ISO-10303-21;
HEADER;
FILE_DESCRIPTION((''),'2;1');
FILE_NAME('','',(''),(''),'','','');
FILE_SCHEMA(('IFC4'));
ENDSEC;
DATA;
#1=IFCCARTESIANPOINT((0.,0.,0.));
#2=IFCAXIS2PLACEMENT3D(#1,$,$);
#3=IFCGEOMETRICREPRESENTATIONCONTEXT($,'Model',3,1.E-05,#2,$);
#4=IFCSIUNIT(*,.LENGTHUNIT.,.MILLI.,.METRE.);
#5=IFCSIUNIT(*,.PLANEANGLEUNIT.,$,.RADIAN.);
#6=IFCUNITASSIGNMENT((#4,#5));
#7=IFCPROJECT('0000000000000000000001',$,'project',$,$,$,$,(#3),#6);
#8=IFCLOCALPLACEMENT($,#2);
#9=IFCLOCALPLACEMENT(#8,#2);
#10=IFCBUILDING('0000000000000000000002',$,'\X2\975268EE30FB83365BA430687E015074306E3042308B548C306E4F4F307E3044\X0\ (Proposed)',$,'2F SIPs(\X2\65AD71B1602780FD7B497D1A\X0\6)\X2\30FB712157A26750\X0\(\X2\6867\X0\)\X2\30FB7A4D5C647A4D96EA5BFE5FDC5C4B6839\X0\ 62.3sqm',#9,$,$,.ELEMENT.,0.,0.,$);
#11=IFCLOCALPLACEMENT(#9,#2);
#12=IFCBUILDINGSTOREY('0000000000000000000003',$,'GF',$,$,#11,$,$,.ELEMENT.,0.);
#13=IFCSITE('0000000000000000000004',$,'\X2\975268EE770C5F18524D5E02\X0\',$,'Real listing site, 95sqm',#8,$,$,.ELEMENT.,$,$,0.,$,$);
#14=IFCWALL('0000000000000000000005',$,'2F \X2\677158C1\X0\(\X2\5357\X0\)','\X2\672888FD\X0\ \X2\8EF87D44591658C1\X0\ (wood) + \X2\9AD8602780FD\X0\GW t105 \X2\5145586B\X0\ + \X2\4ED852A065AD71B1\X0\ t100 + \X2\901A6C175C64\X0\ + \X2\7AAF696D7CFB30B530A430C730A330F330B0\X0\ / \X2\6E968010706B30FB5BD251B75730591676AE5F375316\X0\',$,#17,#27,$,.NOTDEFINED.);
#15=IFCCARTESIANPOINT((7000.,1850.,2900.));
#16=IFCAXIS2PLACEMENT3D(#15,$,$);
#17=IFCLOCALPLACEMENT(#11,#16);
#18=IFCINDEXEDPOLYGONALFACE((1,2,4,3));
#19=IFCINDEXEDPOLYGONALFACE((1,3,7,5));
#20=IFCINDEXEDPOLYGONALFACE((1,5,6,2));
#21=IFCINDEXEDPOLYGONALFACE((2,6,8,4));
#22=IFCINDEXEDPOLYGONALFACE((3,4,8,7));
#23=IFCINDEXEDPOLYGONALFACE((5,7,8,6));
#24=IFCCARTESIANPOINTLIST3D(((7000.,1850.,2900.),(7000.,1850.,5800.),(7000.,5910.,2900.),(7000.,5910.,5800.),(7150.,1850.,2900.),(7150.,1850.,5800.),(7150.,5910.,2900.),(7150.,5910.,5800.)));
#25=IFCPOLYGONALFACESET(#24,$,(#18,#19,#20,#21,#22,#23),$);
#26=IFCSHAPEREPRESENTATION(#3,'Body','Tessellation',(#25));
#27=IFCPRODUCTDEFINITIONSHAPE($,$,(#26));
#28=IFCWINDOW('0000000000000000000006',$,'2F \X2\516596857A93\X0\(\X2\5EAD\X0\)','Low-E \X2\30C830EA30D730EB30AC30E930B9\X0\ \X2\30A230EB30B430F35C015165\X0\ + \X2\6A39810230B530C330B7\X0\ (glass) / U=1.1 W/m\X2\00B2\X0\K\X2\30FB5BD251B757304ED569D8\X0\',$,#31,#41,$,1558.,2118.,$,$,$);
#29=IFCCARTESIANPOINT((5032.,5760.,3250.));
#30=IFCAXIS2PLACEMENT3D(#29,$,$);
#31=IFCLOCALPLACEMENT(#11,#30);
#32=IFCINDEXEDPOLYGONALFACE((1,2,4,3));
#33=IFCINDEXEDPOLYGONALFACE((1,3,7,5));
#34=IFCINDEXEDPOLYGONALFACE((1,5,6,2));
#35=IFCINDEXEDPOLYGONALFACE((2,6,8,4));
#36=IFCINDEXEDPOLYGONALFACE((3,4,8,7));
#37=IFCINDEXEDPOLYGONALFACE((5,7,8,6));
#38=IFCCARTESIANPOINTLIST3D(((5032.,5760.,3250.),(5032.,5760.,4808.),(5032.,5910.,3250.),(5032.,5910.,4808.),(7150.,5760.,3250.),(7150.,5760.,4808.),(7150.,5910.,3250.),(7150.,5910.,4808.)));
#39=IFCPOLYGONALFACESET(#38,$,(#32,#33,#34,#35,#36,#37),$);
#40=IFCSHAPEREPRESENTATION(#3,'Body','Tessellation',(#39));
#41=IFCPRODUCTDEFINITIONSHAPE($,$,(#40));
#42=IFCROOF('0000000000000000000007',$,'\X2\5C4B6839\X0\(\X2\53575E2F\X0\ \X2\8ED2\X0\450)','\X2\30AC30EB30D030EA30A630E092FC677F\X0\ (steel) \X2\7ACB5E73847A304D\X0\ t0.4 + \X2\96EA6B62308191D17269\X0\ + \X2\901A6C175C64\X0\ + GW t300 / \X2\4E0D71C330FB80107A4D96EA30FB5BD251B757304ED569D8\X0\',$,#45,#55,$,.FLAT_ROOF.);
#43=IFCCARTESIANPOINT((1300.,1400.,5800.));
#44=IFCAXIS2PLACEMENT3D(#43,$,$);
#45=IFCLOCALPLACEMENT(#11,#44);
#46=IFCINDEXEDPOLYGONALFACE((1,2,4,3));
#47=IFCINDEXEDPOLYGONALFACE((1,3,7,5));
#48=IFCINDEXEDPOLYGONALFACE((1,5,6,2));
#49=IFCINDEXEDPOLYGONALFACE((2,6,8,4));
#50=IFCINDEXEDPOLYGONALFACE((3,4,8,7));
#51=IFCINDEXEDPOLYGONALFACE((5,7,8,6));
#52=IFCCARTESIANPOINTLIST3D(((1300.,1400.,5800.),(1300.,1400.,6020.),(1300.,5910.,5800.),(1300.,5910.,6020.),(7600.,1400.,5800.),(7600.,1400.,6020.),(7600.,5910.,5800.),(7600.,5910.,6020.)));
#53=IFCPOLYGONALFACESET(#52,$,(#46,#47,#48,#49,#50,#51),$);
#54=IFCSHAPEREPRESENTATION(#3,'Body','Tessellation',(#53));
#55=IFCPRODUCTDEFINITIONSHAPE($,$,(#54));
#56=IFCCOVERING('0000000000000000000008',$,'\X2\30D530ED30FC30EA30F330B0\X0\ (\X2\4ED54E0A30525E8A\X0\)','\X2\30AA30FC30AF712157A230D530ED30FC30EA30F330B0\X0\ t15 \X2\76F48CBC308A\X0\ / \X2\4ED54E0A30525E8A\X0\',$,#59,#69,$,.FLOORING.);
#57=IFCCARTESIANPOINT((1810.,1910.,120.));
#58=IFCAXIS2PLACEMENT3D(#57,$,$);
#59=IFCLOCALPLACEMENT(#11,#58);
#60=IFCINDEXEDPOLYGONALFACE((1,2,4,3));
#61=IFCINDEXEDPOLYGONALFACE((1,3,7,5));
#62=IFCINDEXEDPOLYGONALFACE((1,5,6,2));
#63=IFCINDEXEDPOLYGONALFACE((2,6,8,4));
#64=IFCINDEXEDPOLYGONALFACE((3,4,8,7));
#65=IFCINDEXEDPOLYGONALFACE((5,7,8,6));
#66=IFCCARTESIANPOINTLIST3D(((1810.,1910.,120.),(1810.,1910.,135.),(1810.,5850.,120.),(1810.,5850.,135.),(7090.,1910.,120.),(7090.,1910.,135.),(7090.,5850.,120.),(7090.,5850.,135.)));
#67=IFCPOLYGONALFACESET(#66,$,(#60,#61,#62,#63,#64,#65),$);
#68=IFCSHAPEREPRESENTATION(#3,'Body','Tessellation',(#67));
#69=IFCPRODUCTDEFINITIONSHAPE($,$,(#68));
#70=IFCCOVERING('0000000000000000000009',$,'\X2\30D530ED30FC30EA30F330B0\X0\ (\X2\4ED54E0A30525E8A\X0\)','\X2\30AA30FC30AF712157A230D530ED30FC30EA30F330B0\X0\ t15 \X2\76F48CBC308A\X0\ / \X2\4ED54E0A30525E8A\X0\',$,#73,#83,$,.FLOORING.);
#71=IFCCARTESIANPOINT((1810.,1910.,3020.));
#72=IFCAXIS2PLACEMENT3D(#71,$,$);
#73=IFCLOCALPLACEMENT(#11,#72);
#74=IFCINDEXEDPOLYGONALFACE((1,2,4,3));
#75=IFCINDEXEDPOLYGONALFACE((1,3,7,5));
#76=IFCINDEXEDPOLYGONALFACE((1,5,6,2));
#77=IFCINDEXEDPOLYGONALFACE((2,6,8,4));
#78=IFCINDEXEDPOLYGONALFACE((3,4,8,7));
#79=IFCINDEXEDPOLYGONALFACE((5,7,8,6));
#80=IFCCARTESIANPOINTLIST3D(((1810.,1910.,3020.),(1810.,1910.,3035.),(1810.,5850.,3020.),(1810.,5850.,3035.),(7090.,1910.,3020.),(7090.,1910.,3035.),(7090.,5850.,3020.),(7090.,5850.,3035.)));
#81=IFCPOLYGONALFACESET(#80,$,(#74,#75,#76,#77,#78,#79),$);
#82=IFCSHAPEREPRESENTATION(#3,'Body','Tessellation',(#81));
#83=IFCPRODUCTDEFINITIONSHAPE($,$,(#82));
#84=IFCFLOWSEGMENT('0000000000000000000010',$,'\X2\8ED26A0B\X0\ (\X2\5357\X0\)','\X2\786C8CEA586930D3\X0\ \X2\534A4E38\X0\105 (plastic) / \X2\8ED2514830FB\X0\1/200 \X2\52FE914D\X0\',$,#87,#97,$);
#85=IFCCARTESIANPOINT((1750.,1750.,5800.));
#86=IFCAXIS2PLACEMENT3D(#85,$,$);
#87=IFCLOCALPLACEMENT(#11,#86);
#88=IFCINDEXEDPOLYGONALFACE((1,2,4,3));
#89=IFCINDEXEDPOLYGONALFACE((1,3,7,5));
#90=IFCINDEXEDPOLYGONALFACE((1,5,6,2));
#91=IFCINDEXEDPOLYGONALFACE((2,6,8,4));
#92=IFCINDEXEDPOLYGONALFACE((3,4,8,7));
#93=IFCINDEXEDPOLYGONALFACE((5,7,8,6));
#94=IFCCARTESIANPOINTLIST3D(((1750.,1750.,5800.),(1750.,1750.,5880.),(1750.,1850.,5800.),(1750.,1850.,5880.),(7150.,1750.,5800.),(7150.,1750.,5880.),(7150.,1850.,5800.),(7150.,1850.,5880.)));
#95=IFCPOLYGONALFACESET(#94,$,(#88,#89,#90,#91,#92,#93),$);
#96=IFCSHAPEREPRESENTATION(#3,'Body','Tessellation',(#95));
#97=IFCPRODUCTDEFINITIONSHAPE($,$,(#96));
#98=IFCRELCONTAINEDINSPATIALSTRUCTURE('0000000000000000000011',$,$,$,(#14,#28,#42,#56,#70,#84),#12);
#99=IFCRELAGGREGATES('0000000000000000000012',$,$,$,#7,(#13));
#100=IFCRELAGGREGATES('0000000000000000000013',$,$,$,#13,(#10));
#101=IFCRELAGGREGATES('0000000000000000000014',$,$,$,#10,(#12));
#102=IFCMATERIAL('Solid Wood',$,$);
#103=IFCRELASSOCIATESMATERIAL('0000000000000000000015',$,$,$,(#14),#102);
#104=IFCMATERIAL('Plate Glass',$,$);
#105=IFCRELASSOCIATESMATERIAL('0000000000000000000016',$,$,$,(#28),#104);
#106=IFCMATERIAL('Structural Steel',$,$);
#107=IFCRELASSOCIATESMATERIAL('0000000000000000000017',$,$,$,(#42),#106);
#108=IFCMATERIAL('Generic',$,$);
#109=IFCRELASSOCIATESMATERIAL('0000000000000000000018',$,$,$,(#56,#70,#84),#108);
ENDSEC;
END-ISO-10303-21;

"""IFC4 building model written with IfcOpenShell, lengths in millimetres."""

from ifc_helpers import new_model, si_unit, frame, frame_2d, origin, place, context, project, spatial, rectangle, extrude, material, element, fill, save


model = new_model("IFC4")

# Units and contexts
model_context = context("Model", 3, precision=1e-05, world=origin())
ifc_project = project(units=[si_unit("LENGTHUNIT", "METRE", prefix="MILLI"), si_unit("PLANEANGLEUNIT", "RADIAN")], contexts=[model_context])

# Site, building, storey
site_placement = place(None, origin())
site = spatial("IfcSite", under=ifc_project, at=site_placement, Name="青森県弘前市", ObjectType="Real listing site, 95sqm", CompositionType="ELEMENT", RefElevation=0.0)
building_placement = place(site_placement, origin())
building = spatial("IfcBuilding", under=site, at=building_placement, Name="青森・茶室と縁側のある和の住まい (Proposed)", ObjectType="2F SIPs(断熱性能等級6)・無垢材(桧)・積層積雪対応屋根 62.3sqm", CompositionType="ELEMENT", ElevationOfRefHeight=0.0, ElevationOfTerrain=0.0)
storey_placement = place(building_placement, origin())
storey = spatial("IfcBuildingStorey", under=building, at=storey_placement, Name="GF", CompositionType="ELEMENT", Elevation=0.0)

# Shared definitions
ifc_material_1 = material(Name="Solid Wood")

# Shared definitions
ifc_material_2 = material(Name="Plate Glass")

# Wall, opening, window
wall_1_placement = place(storey_placement, frame((7000.0, 1850.0, 2900.0)))
wall_1 = element("IfcWall", 1, at=wall_1_placement, inside=storey, material=ifc_material_1, Name="2F 東壁(南)", Description="木製 軸組外壁 (wood) + 高性能GW t105 充填 + 付加断熱 t100 + 通気層 + 窯業系サイディング / 準耐火・寒冷地外皮強化", PredefinedType="NOTDEFINED", context=model_context, shape_type="SweptSolid", body=[
    extrude(rectangle(XDim=150.0, YDim=4060.0, at=frame_2d((75.0, 2030.0))), frame((7000.0, 1850.0, 2900.0)), (0.0, 0.0, 1.0), 2900.0),
])
opening_1_placement = place(storey_placement, frame((5032.0, 5760.0, 3250.0)))
opening_1 = element("IfcOpeningElement", 2, at=opening_1_placement, cuts=wall_1, PredefinedType="NOTDEFINED", context=model_context, shape_type="SweptSolid", body=[
    extrude(rectangle(XDim=2118.0, YDim=150.0, at=frame_2d((1059.0, 75.0))), frame((5032.0, 5760.0, 3250.0)), (0.0, 0.0, 1.0), 1558.0),
])
window_1_placement = place(storey_placement, frame((5032.0, 5760.0, 3250.0)))
window_1 = element("IfcWindow", 3, at=window_1_placement, inside=storey, material=ifc_material_2, Name="2F 入隅窓(庭)", Description="Low-E トリプルガラス アルゴン封入 + 樹脂サッシ (glass) / U=1.1 W/m²K・寒冷地仕様", OverallHeight=1558.0, OverallWidth=2118.0, context=model_context, shape_type="SweptSolid", body=[
    extrude(rectangle(XDim=2118.0, YDim=150.0, at=frame_2d((1059.0, 75.0))), frame((5032.0, 5760.0, 3250.0)), (0.0, 0.0, 1.0), 1558.0),
])
fill(opening_1, window_1)

# Roof
ifc_material_3 = material(Name="Structural Steel")
for number, where, name in (
    (4, (1300.0, 1400.0, 5800.0), "屋根(南帯 軒450)"),
):
    element("IfcRoof", number, at=place(storey_placement, frame(where)), inside=storey, material=ifc_material_3, Name=name, Description="ガルバリウム鋼板 (steel) 立平葺き t0.4 + 雪止め金物 + 通気層 + GW t300 / 不燃・耐積雪・寒冷地仕様", PredefinedType="FLAT_ROOF", context=model_context, shape_type="SweptSolid", body=[
        extrude(rectangle(XDim=6300.0, YDim=4510.0, at=frame_2d((3150.0, 2255.0))), frame((1300.0, 1400.0, 5800.0)), (0.0, 0.0, 1.0), 220.0),
    ])

# Coverings
ifc_material_4 = material(Name="Generic")
covering_1_placement = place(storey_placement, frame((1810.0, 1910.0, 120.0)))
element("IfcCovering", 5, at=covering_1_placement, inside=storey, material=ifc_material_4, Name="フローリング (仕上げ床)", Description="オーク無垢フローリング t15 直貼り / 仕上げ床", PredefinedType="FLOORING", context=model_context, shape_type="SweptSolid", body=[
    extrude(rectangle(XDim=5280.0, YDim=3940.0, at=frame_2d((2640.0, 1970.0))), frame((1810.0, 1910.0, 120.0)), (0.0, 0.0, 1.0), 15.0),
])
covering_2_placement = place(storey_placement, frame((1810.0, 1910.0, 3020.0)))
element("IfcCovering", 6, at=covering_2_placement, inside=storey, material=ifc_material_4, Name="フローリング (仕上げ床)", Description="オーク無垢フローリング t15 直貼り / 仕上げ床", PredefinedType="FLOORING", context=model_context, shape_type="SweptSolid", body=[
    extrude(rectangle(XDim=5280.0, YDim=3940.0, at=frame_2d((2640.0, 1970.0))), frame((1810.0, 1910.0, 3020.0)), (0.0, 0.0, 1.0), 15.0),
])

# Flow segment
flow_segment_placement = place(storey_placement, frame((1750.0, 1750.0, 5800.0)))
element("IfcFlowSegment", 7, at=flow_segment_placement, inside=storey, material=ifc_material_4, Name="軒樋 (南)", Description="硬質塩ビ 半丸105 (plastic) / 軒先・1/200 勾配", context=model_context, shape_type="SweptSolid", body=[
    extrude(rectangle(XDim=5400.0, YDim=100.0, at=frame_2d((2700.0, 50.0))), frame((1750.0, 1750.0, 5800.0)), (0.0, 0.0, 1.0), 80.0),
])

save(model, "model.ifc")
